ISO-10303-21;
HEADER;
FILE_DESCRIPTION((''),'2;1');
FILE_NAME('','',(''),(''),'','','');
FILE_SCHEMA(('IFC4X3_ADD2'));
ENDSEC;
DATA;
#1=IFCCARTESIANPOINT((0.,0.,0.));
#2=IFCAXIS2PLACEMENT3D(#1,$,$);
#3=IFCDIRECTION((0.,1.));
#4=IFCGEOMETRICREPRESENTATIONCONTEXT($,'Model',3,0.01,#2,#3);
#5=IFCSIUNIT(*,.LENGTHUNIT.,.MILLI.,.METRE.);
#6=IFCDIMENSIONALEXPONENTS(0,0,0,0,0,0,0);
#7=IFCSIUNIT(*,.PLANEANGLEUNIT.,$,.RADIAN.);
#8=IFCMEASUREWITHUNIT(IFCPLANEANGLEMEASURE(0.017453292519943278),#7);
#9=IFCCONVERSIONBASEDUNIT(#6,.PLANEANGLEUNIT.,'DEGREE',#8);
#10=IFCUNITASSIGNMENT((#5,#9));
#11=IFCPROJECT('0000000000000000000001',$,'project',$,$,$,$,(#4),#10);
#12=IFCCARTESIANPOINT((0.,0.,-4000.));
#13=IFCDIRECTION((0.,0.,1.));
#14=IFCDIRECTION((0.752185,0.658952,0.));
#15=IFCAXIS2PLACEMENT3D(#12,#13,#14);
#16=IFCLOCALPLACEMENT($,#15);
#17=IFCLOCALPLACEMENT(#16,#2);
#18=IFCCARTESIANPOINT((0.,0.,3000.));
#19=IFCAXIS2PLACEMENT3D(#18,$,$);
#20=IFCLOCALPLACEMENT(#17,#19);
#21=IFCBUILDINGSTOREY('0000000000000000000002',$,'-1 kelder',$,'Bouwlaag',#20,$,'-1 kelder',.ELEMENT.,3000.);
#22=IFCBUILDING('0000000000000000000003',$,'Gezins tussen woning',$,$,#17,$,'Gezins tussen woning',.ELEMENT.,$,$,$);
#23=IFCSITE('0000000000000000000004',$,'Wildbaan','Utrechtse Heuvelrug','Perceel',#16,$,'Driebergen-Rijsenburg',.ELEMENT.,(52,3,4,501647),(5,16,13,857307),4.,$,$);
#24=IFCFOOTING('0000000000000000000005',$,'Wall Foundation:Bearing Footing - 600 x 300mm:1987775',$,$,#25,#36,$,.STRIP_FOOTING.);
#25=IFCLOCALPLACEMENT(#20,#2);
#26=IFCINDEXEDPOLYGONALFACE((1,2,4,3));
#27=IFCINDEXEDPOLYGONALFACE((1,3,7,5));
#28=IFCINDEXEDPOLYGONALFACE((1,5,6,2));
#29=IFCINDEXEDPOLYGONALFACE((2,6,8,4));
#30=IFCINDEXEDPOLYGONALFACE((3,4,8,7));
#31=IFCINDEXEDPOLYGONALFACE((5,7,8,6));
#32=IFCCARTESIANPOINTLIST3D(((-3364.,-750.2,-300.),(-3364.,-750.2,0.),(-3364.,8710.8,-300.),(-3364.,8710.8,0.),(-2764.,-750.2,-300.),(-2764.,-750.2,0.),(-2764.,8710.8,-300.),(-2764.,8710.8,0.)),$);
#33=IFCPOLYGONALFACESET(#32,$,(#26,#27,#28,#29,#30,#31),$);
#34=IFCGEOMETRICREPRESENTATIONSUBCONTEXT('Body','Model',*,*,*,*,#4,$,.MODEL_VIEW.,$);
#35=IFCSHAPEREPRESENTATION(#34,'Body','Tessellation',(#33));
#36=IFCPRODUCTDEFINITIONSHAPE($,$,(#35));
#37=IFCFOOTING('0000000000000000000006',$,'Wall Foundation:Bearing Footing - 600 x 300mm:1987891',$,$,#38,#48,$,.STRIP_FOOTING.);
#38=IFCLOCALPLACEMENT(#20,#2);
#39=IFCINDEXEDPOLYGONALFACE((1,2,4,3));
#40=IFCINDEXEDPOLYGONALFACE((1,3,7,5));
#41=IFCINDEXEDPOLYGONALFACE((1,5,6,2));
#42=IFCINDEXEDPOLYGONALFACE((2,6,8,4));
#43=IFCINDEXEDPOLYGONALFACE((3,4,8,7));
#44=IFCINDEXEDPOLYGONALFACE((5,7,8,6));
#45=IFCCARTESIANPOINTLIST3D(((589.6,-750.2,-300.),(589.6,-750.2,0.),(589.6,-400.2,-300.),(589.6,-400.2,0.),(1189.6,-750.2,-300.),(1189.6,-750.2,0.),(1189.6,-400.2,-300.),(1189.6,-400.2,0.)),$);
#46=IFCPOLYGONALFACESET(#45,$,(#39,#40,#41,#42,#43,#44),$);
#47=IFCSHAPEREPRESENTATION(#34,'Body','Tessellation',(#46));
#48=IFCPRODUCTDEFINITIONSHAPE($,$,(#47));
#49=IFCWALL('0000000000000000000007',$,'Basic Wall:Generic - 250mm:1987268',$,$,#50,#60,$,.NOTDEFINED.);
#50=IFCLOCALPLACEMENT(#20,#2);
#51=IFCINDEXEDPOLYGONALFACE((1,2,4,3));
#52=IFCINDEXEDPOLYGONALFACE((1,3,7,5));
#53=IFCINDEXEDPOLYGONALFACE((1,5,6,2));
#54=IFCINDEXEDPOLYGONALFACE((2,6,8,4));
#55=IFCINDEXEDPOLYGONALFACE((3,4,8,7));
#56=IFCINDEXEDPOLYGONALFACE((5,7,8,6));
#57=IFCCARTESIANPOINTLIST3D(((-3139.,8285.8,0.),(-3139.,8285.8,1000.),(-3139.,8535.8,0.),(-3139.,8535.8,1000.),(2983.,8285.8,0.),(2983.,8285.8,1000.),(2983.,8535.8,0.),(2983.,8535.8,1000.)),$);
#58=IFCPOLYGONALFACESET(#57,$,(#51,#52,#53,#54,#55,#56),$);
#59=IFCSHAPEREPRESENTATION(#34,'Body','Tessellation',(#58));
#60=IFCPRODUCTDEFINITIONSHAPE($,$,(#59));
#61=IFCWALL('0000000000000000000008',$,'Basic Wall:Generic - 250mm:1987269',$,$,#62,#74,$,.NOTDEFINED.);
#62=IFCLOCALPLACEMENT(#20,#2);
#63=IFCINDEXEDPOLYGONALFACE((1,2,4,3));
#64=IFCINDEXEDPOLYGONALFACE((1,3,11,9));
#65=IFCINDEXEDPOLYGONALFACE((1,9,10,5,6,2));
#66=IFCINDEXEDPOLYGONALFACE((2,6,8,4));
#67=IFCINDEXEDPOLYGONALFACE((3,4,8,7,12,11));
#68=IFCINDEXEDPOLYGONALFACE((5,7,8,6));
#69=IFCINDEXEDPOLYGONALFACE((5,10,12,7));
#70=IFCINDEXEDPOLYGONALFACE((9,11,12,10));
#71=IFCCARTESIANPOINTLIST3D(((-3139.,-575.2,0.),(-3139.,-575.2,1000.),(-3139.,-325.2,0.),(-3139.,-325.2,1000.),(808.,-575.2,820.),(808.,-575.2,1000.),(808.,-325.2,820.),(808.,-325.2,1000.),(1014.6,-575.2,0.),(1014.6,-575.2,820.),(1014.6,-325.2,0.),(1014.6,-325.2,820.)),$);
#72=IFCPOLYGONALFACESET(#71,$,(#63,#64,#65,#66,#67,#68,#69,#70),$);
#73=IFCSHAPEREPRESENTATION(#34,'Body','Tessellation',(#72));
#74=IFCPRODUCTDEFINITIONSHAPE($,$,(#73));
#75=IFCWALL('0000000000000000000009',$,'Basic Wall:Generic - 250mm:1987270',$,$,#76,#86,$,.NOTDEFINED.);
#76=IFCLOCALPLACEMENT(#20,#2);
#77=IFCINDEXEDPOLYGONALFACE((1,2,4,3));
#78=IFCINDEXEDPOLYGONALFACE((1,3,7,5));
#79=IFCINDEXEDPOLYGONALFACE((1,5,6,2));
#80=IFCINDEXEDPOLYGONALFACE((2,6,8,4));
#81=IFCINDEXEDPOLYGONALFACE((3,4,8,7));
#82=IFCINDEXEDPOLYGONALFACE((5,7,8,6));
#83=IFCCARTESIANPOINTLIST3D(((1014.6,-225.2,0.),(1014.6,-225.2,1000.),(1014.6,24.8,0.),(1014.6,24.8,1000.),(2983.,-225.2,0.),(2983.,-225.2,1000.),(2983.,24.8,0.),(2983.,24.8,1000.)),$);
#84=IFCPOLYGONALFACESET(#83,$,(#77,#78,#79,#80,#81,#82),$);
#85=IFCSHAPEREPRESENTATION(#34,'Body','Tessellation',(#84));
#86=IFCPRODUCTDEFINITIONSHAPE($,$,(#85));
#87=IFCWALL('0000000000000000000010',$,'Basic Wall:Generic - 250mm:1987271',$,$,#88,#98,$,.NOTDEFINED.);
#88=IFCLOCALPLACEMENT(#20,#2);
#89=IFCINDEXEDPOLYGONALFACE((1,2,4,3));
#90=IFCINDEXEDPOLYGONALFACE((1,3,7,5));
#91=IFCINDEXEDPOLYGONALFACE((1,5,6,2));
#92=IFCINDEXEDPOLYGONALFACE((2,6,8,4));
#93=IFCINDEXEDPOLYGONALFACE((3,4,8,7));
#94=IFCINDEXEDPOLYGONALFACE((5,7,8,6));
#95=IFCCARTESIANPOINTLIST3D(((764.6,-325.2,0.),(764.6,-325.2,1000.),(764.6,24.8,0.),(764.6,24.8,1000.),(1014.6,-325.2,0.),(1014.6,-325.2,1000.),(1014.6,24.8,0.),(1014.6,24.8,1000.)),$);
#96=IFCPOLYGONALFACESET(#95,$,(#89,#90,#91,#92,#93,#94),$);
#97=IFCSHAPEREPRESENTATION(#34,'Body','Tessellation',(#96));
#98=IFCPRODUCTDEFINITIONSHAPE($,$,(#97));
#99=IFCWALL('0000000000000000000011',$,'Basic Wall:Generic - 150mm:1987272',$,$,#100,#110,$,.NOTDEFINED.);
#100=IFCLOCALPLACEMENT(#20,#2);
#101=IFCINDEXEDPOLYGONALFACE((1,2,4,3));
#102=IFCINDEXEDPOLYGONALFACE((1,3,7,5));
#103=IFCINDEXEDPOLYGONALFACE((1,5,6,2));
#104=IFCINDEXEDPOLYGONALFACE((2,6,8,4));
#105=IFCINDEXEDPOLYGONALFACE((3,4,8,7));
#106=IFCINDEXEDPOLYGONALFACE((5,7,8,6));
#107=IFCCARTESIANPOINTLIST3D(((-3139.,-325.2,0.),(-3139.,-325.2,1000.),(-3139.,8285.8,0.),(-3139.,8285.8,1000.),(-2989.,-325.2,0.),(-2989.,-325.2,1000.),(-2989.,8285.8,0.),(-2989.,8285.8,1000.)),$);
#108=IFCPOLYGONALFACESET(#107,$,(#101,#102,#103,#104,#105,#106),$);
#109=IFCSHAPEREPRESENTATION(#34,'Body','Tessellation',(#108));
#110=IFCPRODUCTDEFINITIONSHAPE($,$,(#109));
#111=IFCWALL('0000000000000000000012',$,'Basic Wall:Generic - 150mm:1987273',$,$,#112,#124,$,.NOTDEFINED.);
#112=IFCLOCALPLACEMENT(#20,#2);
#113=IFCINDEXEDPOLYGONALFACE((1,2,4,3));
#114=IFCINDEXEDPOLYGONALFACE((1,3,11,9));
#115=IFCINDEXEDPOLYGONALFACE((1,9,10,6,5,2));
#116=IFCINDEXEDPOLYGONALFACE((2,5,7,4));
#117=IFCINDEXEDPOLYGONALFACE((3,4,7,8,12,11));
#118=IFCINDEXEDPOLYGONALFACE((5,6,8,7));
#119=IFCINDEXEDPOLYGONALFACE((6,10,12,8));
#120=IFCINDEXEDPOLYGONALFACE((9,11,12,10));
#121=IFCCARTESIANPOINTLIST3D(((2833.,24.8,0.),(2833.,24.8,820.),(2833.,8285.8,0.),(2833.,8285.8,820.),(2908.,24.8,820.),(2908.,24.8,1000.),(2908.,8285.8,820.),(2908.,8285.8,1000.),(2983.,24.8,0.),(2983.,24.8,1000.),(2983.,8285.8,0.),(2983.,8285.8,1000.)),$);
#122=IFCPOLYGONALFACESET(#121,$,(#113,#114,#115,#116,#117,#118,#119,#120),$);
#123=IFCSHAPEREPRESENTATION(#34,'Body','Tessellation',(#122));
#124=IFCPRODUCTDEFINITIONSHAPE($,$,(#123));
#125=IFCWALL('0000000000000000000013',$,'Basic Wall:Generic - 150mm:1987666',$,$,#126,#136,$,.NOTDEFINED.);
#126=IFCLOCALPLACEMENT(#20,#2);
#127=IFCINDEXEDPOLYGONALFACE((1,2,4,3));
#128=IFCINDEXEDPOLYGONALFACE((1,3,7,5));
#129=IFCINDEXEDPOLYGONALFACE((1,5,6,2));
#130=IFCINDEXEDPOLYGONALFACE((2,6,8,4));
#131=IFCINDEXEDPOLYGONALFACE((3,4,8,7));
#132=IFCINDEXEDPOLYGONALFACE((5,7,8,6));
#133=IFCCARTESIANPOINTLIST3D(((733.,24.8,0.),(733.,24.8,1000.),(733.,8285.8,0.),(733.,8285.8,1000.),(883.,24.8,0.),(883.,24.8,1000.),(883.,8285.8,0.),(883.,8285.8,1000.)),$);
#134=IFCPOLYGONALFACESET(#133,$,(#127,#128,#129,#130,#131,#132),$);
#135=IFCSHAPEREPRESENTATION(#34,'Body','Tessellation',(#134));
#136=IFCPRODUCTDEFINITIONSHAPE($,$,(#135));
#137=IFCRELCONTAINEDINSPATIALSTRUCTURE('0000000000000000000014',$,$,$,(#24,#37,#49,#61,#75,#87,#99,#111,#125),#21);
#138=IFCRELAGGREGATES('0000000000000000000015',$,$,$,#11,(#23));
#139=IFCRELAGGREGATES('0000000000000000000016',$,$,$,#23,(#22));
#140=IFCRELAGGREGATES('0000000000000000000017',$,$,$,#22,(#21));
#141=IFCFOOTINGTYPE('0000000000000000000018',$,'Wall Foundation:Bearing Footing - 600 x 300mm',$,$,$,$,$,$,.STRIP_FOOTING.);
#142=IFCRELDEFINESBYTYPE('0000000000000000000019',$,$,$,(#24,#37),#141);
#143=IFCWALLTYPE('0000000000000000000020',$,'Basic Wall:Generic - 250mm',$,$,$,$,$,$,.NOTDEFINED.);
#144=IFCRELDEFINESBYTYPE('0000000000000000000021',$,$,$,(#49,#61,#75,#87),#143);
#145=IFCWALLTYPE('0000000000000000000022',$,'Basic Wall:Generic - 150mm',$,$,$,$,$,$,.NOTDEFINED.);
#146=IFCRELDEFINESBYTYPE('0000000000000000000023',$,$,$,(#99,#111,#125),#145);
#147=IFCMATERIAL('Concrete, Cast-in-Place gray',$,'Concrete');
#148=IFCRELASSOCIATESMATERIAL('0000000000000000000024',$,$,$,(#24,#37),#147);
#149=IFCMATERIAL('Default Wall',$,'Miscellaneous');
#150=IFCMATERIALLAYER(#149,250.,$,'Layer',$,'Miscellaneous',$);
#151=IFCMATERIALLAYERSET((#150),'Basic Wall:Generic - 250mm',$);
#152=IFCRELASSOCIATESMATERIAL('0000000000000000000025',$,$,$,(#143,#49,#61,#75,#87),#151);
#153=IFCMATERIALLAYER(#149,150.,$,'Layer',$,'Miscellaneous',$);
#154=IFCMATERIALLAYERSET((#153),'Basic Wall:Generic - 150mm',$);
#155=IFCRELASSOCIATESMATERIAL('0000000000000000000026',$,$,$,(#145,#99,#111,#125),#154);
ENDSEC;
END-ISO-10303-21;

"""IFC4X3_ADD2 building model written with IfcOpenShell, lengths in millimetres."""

from ifc_helpers import new_model, entity, si_unit, converted_unit, direction, frame, frame_2d, origin, place, context, subcontext, project, spatial, polyline, rectangle, extrude, clip, bounded_halfspace, material, layer, layer_set, type_object, element, save


model = new_model("IFC4X3_ADD2")

# Units and contexts
model_context = context("Model", 3, precision=0.01, world=origin(), true_north=direction((0.0, 1.0)))
body_context = subcontext(model_context, "Body", "Model", "MODEL_VIEW")
ifc_project = project(units=[si_unit("LENGTHUNIT", "METRE", prefix="MILLI"), converted_unit("PLANEANGLEUNIT", "DEGREE", entity("IfcPlaneAngleMeasure", 0.017453292519943278), si_unit("PLANEANGLEUNIT", "RADIAN"), dimensions=[0, 0, 0, 0, 0, 0, 0])], contexts=[model_context])

# Site, building, storey
site_placement = place(None, frame((0.0, 0.0, -4000.0), z_axis=(0.0, 0.0, 1.0), x_axis=(0.752185, 0.658952, 0.0)))
site = spatial("IfcSite", under=ifc_project, at=site_placement, Name="Wildbaan", Description="Utrechtse Heuvelrug", ObjectType="Perceel", LongName="Driebergen-Rijsenburg", CompositionType="ELEMENT", RefLatitude=(52, 3, 4, 501647), RefLongitude=(5, 16, 13, 857307), RefElevation=4.0)
building_placement = place(site_placement, origin())
building = spatial("IfcBuilding", under=site, at=building_placement, Name="Gezins tussen woning", LongName="Gezins tussen woning", CompositionType="ELEMENT")
storey_placement = place(building_placement, frame((0.0, 0.0, 3000.0)))
storey = spatial("IfcBuildingStorey", under=building, at=storey_placement, Name="-1 kelder", ObjectType="Bouwlaag", LongName="-1 kelder", CompositionType="ELEMENT", Elevation=3000.0)

# Footings
ifc_material_1 = material(Name="Concrete, Cast-in-Place gray", Category="Concrete")
footing_type = type_object("IfcFootingType", Name="Wall Foundation:Bearing Footing - 600 x 300mm", PredefinedType="STRIP_FOOTING")
footing_1_placement = place(storey_placement, frame((-3364.0, -750.2, -300.0)))
element("IfcFooting", 1, at=footing_1_placement, inside=storey, type_object=footing_type, material=ifc_material_1, Name="Wall Foundation:Bearing Footing - 600 x 300mm:1987775", PredefinedType="STRIP_FOOTING", context=body_context, shape_type="SweptSolid", body=[
    extrude(rectangle(XDim=9461.0, YDim=600.0, at=frame_2d((0.0, 100.0), x_axis=(1.0, 0.0))), frame((400.0, 4730.5, 0.0), z_axis=(0.0, 0.0, 1.0), x_axis=(0.0, 1.0, 0.0)), (0.0, 0.0, 1.0), 300.0),
])
footing_2_placement = place(storey_placement, frame((589.6, -750.2, -300.0)))
element("IfcFooting", 2, at=footing_2_placement, inside=storey, type_object=footing_type, material=ifc_material_1, Name="Wall Foundation:Bearing Footing - 600 x 300mm:1987891", PredefinedType="STRIP_FOOTING", context=body_context, shape_type="SweptSolid", body=[
    extrude(rectangle(XDim=350.0, YDim=600.0, at=frame_2d((0.0, 0.0), x_axis=(1.0, 0.0))), frame((300.0, 175.0, 0.0), z_axis=(0.0, 0.0, 1.0), x_axis=(0.0, 1.0, 0.0)), (0.0, 0.0, 1.0), 300.0),
])

# Walls
ifc_material_2 = material(Name="Default Wall", Category="Miscellaneous")
ifc_layer_1 = layer(ifc_material_2, 250.0, Name="Layer", Category="Miscellaneous")
ifc_layer_set_1 = layer_set([ifc_layer_1], Name="Basic Wall:Generic - 250mm")
wall_type_1 = type_object("IfcWallType", Name="Basic Wall:Generic - 250mm", PredefinedType="NOTDEFINED", material=ifc_layer_set_1)
wall_1_placement = place(storey_placement, frame((-3139.0, 8410.8, 0.0)))
element("IfcWall", 3, at=wall_1_placement, inside=storey, type_object=wall_type_1, material=ifc_layer_set_1, Name="Basic Wall:Generic - 250mm:1987268", PredefinedType="NOTDEFINED", context=body_context, shape_type="SweptSolid", body=[
    extrude(rectangle(XDim=6122.0, YDim=250.0, at=frame_2d((3061.0, 0.0), x_axis=(-1.0, 0.0))), origin(), (0.0, 0.0, 1.0), 1000.0),
])
wall_2_placement = place(storey_placement, frame((-3139.0, -450.2, 0.0)))
element("IfcWall", 4, at=wall_2_placement, inside=storey, type_object=wall_type_1, material=ifc_layer_set_1, Name="Basic Wall:Generic - 250mm:1987269", PredefinedType="NOTDEFINED", context=body_context, shape_type="Clipping", body=[
    clip(extrude(rectangle(XDim=4153.6, YDim=250.0, at=frame_2d((2076.8, 0.0), x_axis=(-1.0, 0.0))), origin(), (0.0, 0.0, 1.0), 1000.0), bounded_halfspace(frame((3947.0, -125.0, 820.0), z_axis=(0.0, 0.0, -1.0), x_axis=(0.0, 1.0, 0.0)), True, frame((3947.0, -125.0, 820.0)), polyline([(0.0, 0.0), (206.6, 0.0), (206.6, 250.0), (0.0, 250.0), (0.0, 0.0)]))),
])
wall_3_placement = place(storey_placement, frame((1014.6, -100.2, 0.0)))
element("IfcWall", 5, at=wall_3_placement, inside=storey, type_object=wall_type_1, material=ifc_layer_set_1, Name="Basic Wall:Generic - 250mm:1987270", PredefinedType="NOTDEFINED", context=body_context, shape_type="SweptSolid", body=[
    extrude(rectangle(XDim=1968.4, YDim=250.0, at=frame_2d((984.2, 0.0), x_axis=(-1.0, 0.0))), origin(), (0.0, 0.0, 1.0), 1000.0),
])
wall_4_placement = place(storey_placement, frame((889.6, -325.2, 0.0), z_axis=(0.0, 0.0, 1.0), x_axis=(0.0, 1.0, 0.0)))
element("IfcWall", 6, at=wall_4_placement, inside=storey, type_object=wall_type_1, material=ifc_layer_set_1, Name="Basic Wall:Generic - 250mm:1987271", PredefinedType="NOTDEFINED", context=body_context, shape_type="SweptSolid", body=[
    extrude(rectangle(XDim=350.0, YDim=250.0, at=frame_2d((175.0, 0.0), x_axis=(-1.0, 0.0))), origin(), (0.0, 0.0, 1.0), 1000.0),
])
ifc_layer_2 = layer(ifc_material_2, 150.0, Name="Layer", Category="Miscellaneous")
ifc_layer_set_2 = layer_set([ifc_layer_2], Name="Basic Wall:Generic - 150mm")
wall_type_2 = type_object("IfcWallType", Name="Basic Wall:Generic - 150mm", PredefinedType="NOTDEFINED", material=ifc_layer_set_2)
wall_5_placement = place(storey_placement, frame((-3064.0, -325.2, 0.0), z_axis=(0.0, 0.0, 1.0), x_axis=(0.0, 1.0, 0.0)))
element("IfcWall", 7, at=wall_5_placement, inside=storey, type_object=wall_type_2, material=ifc_layer_set_2, Name="Basic Wall:Generic - 150mm:1987272", PredefinedType="NOTDEFINED", context=body_context, shape_type="SweptSolid", body=[
    extrude(rectangle(XDim=8611.0, YDim=150.0, at=frame_2d((4305.5, 0.0), x_axis=(-1.0, 0.0))), origin(), (0.0, 0.0, 1.0), 1000.0),
])
wall_6_placement = place(storey_placement, frame((2908.0, 24.8, 0.0), z_axis=(0.0, 0.0, 1.0), x_axis=(0.0, 1.0, 0.0)))
element("IfcWall", 8, at=wall_6_placement, inside=storey, type_object=wall_type_2, material=ifc_layer_set_2, Name="Basic Wall:Generic - 150mm:1987273", PredefinedType="NOTDEFINED", context=body_context, shape_type="Clipping", body=[
    clip(extrude(rectangle(XDim=8261.0, YDim=150.0, at=frame_2d((4130.5, 0.0), x_axis=(-1.0, 0.0))), origin(), (0.0, 0.0, 1.0), 1000.0), bounded_halfspace(frame((8261.0, 0.0, 820.0), z_axis=(0.0, 0.0, -1.0), x_axis=(-1.0, 0.0, 0.0)), True, frame((8261.0, 0.0, 820.0)), polyline([(0.0, 0.0), (0.0, 75.0), (-8261.0, 75.0), (-8261.0, 0.0), (0.0, 0.0)]))),
])
wall_7_placement = place(storey_placement, frame((808.0, 24.8, 0.0), z_axis=(0.0, 0.0, 1.0), x_axis=(0.0, 1.0, 0.0)))
element("IfcWall", 9, at=wall_7_placement, inside=storey, type_object=wall_type_2, material=ifc_layer_set_2, Name="Basic Wall:Generic - 150mm:1987666", PredefinedType="NOTDEFINED", context=body_context, shape_type="SweptSolid", body=[
    extrude(rectangle(XDim=8261.0, YDim=150.0, at=frame_2d((4130.5, 0.0), x_axis=(-1.0, 0.0))), origin(), (0.0, 0.0, 1.0), 1000.0),
])

save(model, "model.ifc")
